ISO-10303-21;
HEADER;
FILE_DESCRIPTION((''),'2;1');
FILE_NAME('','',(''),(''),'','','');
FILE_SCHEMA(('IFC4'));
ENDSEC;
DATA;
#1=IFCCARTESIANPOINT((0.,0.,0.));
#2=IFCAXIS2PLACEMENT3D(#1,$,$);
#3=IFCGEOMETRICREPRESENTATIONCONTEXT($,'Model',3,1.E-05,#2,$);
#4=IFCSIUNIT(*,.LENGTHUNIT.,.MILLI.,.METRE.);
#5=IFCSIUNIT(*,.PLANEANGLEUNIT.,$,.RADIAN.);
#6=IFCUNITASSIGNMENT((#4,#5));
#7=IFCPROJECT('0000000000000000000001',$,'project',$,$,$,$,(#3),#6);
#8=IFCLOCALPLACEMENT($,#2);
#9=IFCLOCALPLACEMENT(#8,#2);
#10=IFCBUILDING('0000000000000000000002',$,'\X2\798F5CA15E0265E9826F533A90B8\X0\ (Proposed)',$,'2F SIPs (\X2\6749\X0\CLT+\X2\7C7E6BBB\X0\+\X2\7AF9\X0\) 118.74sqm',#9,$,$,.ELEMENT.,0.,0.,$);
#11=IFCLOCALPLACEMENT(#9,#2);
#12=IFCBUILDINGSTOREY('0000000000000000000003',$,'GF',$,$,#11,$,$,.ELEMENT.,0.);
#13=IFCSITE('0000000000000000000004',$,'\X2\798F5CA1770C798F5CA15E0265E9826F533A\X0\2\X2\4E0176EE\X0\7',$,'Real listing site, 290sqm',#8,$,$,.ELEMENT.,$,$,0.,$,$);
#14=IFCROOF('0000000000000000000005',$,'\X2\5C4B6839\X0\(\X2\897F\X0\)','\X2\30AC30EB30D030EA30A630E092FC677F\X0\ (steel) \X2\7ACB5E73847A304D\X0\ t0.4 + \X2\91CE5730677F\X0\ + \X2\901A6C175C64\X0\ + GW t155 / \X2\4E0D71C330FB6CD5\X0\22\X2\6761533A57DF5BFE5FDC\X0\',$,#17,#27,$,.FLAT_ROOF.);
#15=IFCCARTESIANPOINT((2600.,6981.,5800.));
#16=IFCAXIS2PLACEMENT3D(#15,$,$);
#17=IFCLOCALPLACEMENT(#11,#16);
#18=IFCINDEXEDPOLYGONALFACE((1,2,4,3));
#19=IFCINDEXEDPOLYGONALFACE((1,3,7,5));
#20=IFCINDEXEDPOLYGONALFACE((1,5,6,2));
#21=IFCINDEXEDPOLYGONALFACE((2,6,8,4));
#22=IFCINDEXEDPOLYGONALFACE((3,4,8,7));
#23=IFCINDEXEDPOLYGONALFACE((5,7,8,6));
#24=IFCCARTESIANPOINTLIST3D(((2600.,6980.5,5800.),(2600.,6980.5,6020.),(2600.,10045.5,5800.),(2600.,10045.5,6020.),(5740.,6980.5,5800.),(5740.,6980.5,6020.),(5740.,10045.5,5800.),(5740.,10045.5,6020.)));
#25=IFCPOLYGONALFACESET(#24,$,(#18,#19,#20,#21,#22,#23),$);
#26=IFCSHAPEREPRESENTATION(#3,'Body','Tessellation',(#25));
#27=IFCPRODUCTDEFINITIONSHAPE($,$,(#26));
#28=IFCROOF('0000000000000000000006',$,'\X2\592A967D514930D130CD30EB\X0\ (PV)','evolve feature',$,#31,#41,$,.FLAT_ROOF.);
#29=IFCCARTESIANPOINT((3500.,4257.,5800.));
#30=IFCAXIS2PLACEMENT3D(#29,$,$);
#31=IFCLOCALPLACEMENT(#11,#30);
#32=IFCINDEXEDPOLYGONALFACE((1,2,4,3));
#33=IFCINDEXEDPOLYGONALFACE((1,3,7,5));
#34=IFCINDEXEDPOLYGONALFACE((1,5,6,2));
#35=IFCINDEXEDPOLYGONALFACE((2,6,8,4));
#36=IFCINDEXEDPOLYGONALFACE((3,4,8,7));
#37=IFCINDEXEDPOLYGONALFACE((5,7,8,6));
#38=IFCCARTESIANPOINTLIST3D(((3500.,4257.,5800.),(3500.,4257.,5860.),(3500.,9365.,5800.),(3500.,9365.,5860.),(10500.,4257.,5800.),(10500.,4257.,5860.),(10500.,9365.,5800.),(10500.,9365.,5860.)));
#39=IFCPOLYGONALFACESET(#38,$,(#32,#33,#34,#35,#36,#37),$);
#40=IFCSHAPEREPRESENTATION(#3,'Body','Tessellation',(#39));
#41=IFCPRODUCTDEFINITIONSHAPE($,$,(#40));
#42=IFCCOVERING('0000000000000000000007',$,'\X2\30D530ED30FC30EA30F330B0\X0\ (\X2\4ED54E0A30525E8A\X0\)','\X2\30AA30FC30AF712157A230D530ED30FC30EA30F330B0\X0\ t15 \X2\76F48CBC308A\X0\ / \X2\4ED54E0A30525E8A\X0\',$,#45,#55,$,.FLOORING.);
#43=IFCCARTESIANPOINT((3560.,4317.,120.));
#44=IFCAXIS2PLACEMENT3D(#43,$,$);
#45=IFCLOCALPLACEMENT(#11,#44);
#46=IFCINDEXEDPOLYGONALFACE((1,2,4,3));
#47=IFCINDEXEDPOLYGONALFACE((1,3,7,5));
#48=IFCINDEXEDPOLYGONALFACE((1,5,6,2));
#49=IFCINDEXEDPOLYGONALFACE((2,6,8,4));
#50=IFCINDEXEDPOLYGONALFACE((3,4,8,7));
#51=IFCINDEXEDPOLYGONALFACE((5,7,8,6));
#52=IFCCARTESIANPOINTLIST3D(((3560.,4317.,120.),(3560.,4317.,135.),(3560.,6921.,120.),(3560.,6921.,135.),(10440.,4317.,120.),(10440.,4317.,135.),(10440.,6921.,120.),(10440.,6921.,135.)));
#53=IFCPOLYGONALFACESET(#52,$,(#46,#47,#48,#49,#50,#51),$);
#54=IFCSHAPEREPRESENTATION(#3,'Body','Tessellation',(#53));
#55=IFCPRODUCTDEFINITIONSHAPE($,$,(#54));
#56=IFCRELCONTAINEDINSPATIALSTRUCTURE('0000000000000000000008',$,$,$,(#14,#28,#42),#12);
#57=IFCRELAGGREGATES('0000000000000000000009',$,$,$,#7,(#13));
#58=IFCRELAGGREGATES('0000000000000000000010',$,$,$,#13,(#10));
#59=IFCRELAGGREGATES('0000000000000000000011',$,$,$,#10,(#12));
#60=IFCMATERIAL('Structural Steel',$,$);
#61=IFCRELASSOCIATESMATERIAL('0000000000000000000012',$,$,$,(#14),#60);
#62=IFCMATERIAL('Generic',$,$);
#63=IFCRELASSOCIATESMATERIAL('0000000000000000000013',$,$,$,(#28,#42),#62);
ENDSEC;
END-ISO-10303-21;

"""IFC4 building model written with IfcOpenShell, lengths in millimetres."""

from ifc_helpers import new_model, si_unit, frame, frame_2d, origin, place, context, project, spatial, rectangle, extrude, material, element, save


model = new_model("IFC4")

# Units and contexts
model_context = context("Model", 3, precision=1e-05, world=origin())
ifc_project = project(units=[si_unit("LENGTHUNIT", "METRE", prefix="MILLI"), si_unit("PLANEANGLEUNIT", "RADIAN")], contexts=[model_context])

# Site, building, storey
site_placement = place(None, origin())
site = spatial("IfcSite", under=ifc_project, at=site_placement, Name="福岡県福岡市早良区2丁目7", ObjectType="Real listing site, 290sqm", CompositionType="ELEMENT", RefElevation=0.0)
building_placement = place(site_placement, origin())
building = spatial("IfcBuilding", under=site, at=building_placement, Name="福岡市早良区邸 (Proposed)", ObjectType="2F SIPs (杉CLT+籾殻+竹) 118.74sqm", CompositionType="ELEMENT", ElevationOfRefHeight=0.0, ElevationOfTerrain=0.0)
storey_placement = place(building_placement, origin())
storey = spatial("IfcBuildingStorey", under=building, at=storey_placement, Name="GF", CompositionType="ELEMENT", Elevation=0.0)

# Shared definitions
ifc_material_1 = material(Name="Generic")

# Roofs
ifc_material_2 = material(Name="Structural Steel")
roof_1_placement = place(storey_placement, frame((2600.0, 6981.0, 5800.0)))
element("IfcRoof", 1, at=roof_1_placement, inside=storey, material=ifc_material_2, Name="屋根(西)", Description="ガルバリウム鋼板 (steel) 立平葺き t0.4 + 野地板 + 通気層 + GW t155 / 不燃・法22条区域対応", PredefinedType="FLAT_ROOF", context=model_context, shape_type="SweptSolid", body=[
    extrude(rectangle(XDim=3140.0, YDim=3065.0, at=frame_2d((1570.0, 1532.0))), frame((2600.0, 6981.0, 5800.0)), (0.0, 0.0, 1.0), 220.0),
])
roof_2_placement = place(storey_placement, frame((3500.0, 4257.0, 5800.0)))
element("IfcRoof", 2, at=roof_2_placement, inside=storey, material=ifc_material_1, Name="太陽光パネル (PV)", Description="evolve feature", PredefinedType="FLAT_ROOF", context=model_context, shape_type="SweptSolid", body=[
    extrude(rectangle(XDim=7000.0, YDim=5108.0, at=frame_2d((3500.0, 2554.0))), frame((3500.0, 4257.0, 5800.0)), (0.0, 0.0, 1.0), 60.0),
])

# Covering
covering_placement = place(storey_placement, frame((3560.0, 4317.0, 120.0)))
element("IfcCovering", 3, at=covering_placement, inside=storey, material=ifc_material_1, Name="フローリング (仕上げ床)", Description="オーク無垢フローリング t15 直貼り / 仕上げ床", PredefinedType="FLOORING", context=model_context, shape_type="SweptSolid", body=[
    extrude(rectangle(XDim=6880.0, YDim=2604.0, at=frame_2d((3440.0, 1302.0))), frame((3560.0, 4317.0, 120.0)), (0.0, 0.0, 1.0), 15.0),
])

save(model, "model.ifc")
